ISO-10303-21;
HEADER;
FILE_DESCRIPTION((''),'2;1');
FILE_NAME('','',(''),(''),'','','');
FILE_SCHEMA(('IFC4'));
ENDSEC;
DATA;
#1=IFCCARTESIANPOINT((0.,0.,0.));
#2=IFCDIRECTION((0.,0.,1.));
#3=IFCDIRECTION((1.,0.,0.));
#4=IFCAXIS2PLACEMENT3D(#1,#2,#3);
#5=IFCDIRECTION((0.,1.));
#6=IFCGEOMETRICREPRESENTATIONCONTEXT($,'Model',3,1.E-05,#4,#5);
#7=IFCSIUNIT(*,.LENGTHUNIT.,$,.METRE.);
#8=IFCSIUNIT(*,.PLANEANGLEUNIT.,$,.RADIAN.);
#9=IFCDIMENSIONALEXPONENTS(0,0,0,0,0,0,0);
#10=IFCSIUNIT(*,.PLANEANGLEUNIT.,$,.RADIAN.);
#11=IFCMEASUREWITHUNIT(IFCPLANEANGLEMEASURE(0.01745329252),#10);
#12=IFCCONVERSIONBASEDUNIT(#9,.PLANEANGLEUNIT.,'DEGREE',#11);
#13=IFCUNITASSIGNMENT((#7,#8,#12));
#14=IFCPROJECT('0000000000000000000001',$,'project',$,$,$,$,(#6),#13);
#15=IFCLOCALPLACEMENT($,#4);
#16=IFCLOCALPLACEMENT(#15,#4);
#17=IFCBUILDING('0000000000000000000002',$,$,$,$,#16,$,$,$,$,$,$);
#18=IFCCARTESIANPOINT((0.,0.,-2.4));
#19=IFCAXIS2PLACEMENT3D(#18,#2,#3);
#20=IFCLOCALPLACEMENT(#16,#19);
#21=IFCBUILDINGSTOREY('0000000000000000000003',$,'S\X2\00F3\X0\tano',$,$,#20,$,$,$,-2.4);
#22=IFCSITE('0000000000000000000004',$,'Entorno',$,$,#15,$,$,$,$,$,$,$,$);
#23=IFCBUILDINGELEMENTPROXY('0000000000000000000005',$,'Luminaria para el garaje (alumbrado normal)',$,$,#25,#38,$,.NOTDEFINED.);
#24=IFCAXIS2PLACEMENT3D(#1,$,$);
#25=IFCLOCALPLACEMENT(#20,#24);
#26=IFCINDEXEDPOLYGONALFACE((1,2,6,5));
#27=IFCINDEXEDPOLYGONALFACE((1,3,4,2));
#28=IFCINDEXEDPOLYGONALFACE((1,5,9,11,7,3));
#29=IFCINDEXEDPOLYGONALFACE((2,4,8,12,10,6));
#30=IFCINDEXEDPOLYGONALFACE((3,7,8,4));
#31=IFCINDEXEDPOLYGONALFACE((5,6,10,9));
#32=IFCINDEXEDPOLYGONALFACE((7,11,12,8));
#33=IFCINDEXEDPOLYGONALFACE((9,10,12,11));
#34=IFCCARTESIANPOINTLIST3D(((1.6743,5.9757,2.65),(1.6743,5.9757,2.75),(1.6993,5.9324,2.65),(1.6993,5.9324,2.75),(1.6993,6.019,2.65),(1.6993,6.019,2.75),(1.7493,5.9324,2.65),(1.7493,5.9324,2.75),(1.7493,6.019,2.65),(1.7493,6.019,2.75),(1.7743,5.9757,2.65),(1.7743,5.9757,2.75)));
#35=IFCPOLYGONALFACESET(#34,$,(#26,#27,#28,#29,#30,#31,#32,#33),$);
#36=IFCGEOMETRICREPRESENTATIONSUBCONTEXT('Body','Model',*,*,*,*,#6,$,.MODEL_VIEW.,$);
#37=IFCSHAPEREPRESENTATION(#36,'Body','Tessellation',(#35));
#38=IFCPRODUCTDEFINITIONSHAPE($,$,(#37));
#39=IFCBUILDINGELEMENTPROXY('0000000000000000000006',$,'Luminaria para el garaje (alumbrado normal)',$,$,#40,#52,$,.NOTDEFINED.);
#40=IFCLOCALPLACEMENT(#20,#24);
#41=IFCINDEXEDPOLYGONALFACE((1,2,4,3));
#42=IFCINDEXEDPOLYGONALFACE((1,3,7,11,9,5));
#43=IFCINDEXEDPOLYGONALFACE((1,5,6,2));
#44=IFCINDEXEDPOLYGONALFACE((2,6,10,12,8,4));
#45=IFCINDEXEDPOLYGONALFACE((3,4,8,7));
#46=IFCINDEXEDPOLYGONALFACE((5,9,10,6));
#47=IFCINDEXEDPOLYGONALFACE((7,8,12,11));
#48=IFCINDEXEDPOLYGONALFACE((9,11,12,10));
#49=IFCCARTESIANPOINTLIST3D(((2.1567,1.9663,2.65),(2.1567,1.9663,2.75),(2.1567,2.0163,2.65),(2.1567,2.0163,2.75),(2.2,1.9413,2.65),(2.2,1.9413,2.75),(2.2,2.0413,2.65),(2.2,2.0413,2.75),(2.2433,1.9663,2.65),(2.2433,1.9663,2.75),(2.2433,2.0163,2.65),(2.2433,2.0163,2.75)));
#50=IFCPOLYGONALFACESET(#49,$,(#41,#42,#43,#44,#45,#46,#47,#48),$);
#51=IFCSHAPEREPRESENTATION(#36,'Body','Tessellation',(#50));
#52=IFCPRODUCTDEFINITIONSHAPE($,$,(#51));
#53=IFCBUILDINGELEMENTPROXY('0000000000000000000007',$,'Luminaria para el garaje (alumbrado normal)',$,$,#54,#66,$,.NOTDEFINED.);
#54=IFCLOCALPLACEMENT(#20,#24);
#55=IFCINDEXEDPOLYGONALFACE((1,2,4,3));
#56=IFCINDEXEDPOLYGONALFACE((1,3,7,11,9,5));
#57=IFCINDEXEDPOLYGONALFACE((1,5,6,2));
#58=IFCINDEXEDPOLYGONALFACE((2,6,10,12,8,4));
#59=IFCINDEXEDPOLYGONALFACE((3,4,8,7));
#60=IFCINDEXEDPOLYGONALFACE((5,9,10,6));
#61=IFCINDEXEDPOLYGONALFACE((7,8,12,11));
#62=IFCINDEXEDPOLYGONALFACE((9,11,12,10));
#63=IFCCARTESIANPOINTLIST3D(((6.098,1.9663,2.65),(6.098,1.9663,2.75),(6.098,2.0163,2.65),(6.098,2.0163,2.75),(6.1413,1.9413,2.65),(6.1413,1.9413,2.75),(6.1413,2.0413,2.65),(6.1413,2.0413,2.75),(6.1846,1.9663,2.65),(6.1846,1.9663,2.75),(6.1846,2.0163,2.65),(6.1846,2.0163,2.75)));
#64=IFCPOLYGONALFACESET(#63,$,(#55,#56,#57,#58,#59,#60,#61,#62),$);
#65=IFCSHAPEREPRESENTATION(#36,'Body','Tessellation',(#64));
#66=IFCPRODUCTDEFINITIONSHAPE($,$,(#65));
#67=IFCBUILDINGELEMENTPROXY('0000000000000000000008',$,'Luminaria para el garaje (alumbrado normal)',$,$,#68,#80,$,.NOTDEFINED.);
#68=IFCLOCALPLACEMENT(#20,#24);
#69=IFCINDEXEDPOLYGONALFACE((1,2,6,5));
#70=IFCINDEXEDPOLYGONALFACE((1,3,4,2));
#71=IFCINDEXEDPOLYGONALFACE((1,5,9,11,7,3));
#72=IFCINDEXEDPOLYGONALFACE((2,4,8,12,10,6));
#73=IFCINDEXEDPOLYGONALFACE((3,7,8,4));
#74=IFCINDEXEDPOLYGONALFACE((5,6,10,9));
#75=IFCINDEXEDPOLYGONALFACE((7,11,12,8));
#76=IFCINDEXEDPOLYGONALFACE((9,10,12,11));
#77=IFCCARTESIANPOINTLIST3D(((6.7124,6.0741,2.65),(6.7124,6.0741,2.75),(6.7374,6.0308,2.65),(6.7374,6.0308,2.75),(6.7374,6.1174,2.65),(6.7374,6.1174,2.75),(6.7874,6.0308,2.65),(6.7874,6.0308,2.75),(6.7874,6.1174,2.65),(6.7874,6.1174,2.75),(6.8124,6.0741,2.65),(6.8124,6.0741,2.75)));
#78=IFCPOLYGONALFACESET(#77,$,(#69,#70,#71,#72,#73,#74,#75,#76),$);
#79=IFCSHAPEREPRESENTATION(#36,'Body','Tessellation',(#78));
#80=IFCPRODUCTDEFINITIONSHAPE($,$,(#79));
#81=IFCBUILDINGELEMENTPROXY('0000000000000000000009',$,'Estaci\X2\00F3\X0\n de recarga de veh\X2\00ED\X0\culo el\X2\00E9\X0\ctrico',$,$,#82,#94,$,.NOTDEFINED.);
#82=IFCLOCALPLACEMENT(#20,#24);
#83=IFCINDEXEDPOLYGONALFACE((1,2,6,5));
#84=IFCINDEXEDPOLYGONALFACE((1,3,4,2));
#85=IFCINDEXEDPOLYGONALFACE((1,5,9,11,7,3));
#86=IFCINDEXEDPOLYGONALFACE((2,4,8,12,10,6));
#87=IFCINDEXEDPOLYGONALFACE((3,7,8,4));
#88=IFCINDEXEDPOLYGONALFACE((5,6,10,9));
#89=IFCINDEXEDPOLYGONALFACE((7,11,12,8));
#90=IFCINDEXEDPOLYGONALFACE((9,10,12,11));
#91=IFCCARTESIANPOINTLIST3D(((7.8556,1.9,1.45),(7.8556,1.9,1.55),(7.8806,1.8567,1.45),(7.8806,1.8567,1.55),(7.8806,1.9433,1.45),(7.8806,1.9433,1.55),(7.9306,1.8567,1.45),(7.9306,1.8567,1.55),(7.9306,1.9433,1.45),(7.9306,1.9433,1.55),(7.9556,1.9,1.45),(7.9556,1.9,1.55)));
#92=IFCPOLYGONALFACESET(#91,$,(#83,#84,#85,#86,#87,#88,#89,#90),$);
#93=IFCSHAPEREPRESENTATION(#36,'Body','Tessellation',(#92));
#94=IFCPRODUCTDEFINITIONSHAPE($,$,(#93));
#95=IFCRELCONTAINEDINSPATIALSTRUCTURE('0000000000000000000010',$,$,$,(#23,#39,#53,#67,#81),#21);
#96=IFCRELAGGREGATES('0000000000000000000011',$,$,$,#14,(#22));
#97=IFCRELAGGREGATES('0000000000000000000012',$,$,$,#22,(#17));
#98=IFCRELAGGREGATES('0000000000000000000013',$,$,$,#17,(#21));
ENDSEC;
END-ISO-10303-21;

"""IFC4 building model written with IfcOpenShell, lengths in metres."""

from ifc_helpers import new_model, entity, si_unit, converted_unit, direction, frame, origin_with_axes, place, context, subcontext, project, spatial, polyline, outline, extrude, source, transform, mapped, element, save


model = new_model("IFC4")

# Units and contexts
model_context = context("Model", 3, precision=1e-05, world=origin_with_axes(), true_north=direction((0.0, 1.0)))
body_context = subcontext(model_context, "Body", "Model", "MODEL_VIEW")
ifc_project = project(units=[si_unit("LENGTHUNIT", "METRE"), si_unit("PLANEANGLEUNIT", "RADIAN"), converted_unit("PLANEANGLEUNIT", "DEGREE", entity("IfcPlaneAngleMeasure", 0.01745329252), si_unit("PLANEANGLEUNIT", "RADIAN"), dimensions=[0, 0, 0, 0, 0, 0, 0])], contexts=[model_context])

# Site, building, storey
site_placement = place(None, origin_with_axes())
site = spatial("IfcSite", under=ifc_project, at=site_placement, Name="Entorno")
building_placement = place(site_placement, origin_with_axes())
building = spatial("IfcBuilding", under=site, at=building_placement)
storey_placement = place(building_placement, frame((0.0, 0.0, -2.4), z_axis=(0.0, 0.0, 1.0), x_axis=(1.0, 0.0, 0.0)))
storey = spatial("IfcBuildingStorey", under=building, at=storey_placement, Name="Sótano", Elevation=-2.4)

# Building element proxies
shared_shape_1 = source(origin_with_axes(), body_context, "Body", "SolidModel", [
    extrude(outline(polyline([(0.05, 0.0), (0.025, 0.0433), (-0.025, 0.0433), (-0.05, 0.0), (-0.025, -0.0433), (0.025, -0.0433), (0.05, 0.0)])), frame((0.0, 0.0, -0.05), z_axis=(0.0, 0.0, 1.0), x_axis=(1.0, 0.0, 0.0)), (0.0, 0.0, 1.0), 0.1),
])
proxy_1_placement = place(storey_placement, frame((0.0, 0.0, 2.4), z_axis=(0.0, 0.0, 1.0), x_axis=(1.0, 0.0, 0.0)))
element("IfcBuildingElementProxy", 1, at=proxy_1_placement, inside=storey, Name="Luminaria para el garaje (alumbrado normal)", PredefinedType="NOTDEFINED", context=body_context, shape_type="Brep", body=[
    mapped(shared_shape_1, transform((1.7243, 5.9757, 0.3), x_axis=(1.0, 0.0, 0.0), y_axis=(0.0, 1.0, 0.0), z_axis=(0.0, 0.0, 1.0))),
])
proxy_2_placement = place(storey_placement, frame((0.0, 0.0, 2.4), z_axis=(0.0, 0.0, 1.0), x_axis=(1.0, 0.0, 0.0)))
element("IfcBuildingElementProxy", 2, at=proxy_2_placement, inside=storey, Name="Luminaria para el garaje (alumbrado normal)", PredefinedType="NOTDEFINED", context=body_context, shape_type="Brep", body=[
    mapped(shared_shape_1, transform((2.2, 1.9913, 0.3), x_axis=(0.0, 1.0, 0.0), y_axis=(-1.0, 0.0, 0.0), z_axis=(0.0, 0.0, 1.0))),
])
proxy_3_placement = place(storey_placement, frame((0.0, 0.0, 2.4), z_axis=(0.0, 0.0, 1.0), x_axis=(1.0, 0.0, 0.0)))
element("IfcBuildingElementProxy", 3, at=proxy_3_placement, inside=storey, Name="Luminaria para el garaje (alumbrado normal)", PredefinedType="NOTDEFINED", context=body_context, shape_type="Brep", body=[
    mapped(shared_shape_1, transform((6.1413, 1.9913, 0.3), x_axis=(0.0, 1.0, 0.0), y_axis=(-1.0, 0.0, 0.0), z_axis=(0.0, 0.0, 1.0))),
])
proxy_4_placement = place(storey_placement, frame((0.0, 0.0, 2.4), z_axis=(0.0, 0.0, 1.0), x_axis=(1.0, 0.0, 0.0)))
element("IfcBuildingElementProxy", 4, at=proxy_4_placement, inside=storey, Name="Luminaria para el garaje (alumbrado normal)", PredefinedType="NOTDEFINED", context=body_context, shape_type="Brep", body=[
    mapped(shared_shape_1, transform((6.7623, 6.0741, 0.3), x_axis=(-1.0, 0.0, 0.0), y_axis=(0.0, -1.0, 0.0), z_axis=(0.0, 0.0, 1.0))),
])
shared_shape_2 = source(origin_with_axes(), body_context, "Body", "SolidModel", [
    extrude(outline(polyline([(0.05, 0.0), (0.025, 0.0433), (-0.025, 0.0433), (-0.05, 0.0), (-0.025, -0.0433), (0.025, -0.0433), (0.05, 0.0)])), frame((0.0, 0.0, -0.05), z_axis=(0.0, 0.0, 1.0), x_axis=(1.0, 0.0, 0.0)), (0.0, 0.0, 1.0), 0.1),
])
proxy_5_placement = place(storey_placement, frame((0.0, 0.0, 2.4), z_axis=(0.0, 0.0, 1.0), x_axis=(1.0, 0.0, 0.0)))
element("IfcBuildingElementProxy", 5, at=proxy_5_placement, inside=storey, Name="Estación de recarga de vehículo eléctrico", PredefinedType="NOTDEFINED", context=body_context, shape_type="Brep", body=[
    mapped(shared_shape_2, transform((7.9056, 1.9, -0.9), x_axis=(1.0, 0.0, 0.0), y_axis=(0.0, 1.0, 0.0), z_axis=(0.0, 0.0, 1.0))),
])

save(model, "model.ifc")
